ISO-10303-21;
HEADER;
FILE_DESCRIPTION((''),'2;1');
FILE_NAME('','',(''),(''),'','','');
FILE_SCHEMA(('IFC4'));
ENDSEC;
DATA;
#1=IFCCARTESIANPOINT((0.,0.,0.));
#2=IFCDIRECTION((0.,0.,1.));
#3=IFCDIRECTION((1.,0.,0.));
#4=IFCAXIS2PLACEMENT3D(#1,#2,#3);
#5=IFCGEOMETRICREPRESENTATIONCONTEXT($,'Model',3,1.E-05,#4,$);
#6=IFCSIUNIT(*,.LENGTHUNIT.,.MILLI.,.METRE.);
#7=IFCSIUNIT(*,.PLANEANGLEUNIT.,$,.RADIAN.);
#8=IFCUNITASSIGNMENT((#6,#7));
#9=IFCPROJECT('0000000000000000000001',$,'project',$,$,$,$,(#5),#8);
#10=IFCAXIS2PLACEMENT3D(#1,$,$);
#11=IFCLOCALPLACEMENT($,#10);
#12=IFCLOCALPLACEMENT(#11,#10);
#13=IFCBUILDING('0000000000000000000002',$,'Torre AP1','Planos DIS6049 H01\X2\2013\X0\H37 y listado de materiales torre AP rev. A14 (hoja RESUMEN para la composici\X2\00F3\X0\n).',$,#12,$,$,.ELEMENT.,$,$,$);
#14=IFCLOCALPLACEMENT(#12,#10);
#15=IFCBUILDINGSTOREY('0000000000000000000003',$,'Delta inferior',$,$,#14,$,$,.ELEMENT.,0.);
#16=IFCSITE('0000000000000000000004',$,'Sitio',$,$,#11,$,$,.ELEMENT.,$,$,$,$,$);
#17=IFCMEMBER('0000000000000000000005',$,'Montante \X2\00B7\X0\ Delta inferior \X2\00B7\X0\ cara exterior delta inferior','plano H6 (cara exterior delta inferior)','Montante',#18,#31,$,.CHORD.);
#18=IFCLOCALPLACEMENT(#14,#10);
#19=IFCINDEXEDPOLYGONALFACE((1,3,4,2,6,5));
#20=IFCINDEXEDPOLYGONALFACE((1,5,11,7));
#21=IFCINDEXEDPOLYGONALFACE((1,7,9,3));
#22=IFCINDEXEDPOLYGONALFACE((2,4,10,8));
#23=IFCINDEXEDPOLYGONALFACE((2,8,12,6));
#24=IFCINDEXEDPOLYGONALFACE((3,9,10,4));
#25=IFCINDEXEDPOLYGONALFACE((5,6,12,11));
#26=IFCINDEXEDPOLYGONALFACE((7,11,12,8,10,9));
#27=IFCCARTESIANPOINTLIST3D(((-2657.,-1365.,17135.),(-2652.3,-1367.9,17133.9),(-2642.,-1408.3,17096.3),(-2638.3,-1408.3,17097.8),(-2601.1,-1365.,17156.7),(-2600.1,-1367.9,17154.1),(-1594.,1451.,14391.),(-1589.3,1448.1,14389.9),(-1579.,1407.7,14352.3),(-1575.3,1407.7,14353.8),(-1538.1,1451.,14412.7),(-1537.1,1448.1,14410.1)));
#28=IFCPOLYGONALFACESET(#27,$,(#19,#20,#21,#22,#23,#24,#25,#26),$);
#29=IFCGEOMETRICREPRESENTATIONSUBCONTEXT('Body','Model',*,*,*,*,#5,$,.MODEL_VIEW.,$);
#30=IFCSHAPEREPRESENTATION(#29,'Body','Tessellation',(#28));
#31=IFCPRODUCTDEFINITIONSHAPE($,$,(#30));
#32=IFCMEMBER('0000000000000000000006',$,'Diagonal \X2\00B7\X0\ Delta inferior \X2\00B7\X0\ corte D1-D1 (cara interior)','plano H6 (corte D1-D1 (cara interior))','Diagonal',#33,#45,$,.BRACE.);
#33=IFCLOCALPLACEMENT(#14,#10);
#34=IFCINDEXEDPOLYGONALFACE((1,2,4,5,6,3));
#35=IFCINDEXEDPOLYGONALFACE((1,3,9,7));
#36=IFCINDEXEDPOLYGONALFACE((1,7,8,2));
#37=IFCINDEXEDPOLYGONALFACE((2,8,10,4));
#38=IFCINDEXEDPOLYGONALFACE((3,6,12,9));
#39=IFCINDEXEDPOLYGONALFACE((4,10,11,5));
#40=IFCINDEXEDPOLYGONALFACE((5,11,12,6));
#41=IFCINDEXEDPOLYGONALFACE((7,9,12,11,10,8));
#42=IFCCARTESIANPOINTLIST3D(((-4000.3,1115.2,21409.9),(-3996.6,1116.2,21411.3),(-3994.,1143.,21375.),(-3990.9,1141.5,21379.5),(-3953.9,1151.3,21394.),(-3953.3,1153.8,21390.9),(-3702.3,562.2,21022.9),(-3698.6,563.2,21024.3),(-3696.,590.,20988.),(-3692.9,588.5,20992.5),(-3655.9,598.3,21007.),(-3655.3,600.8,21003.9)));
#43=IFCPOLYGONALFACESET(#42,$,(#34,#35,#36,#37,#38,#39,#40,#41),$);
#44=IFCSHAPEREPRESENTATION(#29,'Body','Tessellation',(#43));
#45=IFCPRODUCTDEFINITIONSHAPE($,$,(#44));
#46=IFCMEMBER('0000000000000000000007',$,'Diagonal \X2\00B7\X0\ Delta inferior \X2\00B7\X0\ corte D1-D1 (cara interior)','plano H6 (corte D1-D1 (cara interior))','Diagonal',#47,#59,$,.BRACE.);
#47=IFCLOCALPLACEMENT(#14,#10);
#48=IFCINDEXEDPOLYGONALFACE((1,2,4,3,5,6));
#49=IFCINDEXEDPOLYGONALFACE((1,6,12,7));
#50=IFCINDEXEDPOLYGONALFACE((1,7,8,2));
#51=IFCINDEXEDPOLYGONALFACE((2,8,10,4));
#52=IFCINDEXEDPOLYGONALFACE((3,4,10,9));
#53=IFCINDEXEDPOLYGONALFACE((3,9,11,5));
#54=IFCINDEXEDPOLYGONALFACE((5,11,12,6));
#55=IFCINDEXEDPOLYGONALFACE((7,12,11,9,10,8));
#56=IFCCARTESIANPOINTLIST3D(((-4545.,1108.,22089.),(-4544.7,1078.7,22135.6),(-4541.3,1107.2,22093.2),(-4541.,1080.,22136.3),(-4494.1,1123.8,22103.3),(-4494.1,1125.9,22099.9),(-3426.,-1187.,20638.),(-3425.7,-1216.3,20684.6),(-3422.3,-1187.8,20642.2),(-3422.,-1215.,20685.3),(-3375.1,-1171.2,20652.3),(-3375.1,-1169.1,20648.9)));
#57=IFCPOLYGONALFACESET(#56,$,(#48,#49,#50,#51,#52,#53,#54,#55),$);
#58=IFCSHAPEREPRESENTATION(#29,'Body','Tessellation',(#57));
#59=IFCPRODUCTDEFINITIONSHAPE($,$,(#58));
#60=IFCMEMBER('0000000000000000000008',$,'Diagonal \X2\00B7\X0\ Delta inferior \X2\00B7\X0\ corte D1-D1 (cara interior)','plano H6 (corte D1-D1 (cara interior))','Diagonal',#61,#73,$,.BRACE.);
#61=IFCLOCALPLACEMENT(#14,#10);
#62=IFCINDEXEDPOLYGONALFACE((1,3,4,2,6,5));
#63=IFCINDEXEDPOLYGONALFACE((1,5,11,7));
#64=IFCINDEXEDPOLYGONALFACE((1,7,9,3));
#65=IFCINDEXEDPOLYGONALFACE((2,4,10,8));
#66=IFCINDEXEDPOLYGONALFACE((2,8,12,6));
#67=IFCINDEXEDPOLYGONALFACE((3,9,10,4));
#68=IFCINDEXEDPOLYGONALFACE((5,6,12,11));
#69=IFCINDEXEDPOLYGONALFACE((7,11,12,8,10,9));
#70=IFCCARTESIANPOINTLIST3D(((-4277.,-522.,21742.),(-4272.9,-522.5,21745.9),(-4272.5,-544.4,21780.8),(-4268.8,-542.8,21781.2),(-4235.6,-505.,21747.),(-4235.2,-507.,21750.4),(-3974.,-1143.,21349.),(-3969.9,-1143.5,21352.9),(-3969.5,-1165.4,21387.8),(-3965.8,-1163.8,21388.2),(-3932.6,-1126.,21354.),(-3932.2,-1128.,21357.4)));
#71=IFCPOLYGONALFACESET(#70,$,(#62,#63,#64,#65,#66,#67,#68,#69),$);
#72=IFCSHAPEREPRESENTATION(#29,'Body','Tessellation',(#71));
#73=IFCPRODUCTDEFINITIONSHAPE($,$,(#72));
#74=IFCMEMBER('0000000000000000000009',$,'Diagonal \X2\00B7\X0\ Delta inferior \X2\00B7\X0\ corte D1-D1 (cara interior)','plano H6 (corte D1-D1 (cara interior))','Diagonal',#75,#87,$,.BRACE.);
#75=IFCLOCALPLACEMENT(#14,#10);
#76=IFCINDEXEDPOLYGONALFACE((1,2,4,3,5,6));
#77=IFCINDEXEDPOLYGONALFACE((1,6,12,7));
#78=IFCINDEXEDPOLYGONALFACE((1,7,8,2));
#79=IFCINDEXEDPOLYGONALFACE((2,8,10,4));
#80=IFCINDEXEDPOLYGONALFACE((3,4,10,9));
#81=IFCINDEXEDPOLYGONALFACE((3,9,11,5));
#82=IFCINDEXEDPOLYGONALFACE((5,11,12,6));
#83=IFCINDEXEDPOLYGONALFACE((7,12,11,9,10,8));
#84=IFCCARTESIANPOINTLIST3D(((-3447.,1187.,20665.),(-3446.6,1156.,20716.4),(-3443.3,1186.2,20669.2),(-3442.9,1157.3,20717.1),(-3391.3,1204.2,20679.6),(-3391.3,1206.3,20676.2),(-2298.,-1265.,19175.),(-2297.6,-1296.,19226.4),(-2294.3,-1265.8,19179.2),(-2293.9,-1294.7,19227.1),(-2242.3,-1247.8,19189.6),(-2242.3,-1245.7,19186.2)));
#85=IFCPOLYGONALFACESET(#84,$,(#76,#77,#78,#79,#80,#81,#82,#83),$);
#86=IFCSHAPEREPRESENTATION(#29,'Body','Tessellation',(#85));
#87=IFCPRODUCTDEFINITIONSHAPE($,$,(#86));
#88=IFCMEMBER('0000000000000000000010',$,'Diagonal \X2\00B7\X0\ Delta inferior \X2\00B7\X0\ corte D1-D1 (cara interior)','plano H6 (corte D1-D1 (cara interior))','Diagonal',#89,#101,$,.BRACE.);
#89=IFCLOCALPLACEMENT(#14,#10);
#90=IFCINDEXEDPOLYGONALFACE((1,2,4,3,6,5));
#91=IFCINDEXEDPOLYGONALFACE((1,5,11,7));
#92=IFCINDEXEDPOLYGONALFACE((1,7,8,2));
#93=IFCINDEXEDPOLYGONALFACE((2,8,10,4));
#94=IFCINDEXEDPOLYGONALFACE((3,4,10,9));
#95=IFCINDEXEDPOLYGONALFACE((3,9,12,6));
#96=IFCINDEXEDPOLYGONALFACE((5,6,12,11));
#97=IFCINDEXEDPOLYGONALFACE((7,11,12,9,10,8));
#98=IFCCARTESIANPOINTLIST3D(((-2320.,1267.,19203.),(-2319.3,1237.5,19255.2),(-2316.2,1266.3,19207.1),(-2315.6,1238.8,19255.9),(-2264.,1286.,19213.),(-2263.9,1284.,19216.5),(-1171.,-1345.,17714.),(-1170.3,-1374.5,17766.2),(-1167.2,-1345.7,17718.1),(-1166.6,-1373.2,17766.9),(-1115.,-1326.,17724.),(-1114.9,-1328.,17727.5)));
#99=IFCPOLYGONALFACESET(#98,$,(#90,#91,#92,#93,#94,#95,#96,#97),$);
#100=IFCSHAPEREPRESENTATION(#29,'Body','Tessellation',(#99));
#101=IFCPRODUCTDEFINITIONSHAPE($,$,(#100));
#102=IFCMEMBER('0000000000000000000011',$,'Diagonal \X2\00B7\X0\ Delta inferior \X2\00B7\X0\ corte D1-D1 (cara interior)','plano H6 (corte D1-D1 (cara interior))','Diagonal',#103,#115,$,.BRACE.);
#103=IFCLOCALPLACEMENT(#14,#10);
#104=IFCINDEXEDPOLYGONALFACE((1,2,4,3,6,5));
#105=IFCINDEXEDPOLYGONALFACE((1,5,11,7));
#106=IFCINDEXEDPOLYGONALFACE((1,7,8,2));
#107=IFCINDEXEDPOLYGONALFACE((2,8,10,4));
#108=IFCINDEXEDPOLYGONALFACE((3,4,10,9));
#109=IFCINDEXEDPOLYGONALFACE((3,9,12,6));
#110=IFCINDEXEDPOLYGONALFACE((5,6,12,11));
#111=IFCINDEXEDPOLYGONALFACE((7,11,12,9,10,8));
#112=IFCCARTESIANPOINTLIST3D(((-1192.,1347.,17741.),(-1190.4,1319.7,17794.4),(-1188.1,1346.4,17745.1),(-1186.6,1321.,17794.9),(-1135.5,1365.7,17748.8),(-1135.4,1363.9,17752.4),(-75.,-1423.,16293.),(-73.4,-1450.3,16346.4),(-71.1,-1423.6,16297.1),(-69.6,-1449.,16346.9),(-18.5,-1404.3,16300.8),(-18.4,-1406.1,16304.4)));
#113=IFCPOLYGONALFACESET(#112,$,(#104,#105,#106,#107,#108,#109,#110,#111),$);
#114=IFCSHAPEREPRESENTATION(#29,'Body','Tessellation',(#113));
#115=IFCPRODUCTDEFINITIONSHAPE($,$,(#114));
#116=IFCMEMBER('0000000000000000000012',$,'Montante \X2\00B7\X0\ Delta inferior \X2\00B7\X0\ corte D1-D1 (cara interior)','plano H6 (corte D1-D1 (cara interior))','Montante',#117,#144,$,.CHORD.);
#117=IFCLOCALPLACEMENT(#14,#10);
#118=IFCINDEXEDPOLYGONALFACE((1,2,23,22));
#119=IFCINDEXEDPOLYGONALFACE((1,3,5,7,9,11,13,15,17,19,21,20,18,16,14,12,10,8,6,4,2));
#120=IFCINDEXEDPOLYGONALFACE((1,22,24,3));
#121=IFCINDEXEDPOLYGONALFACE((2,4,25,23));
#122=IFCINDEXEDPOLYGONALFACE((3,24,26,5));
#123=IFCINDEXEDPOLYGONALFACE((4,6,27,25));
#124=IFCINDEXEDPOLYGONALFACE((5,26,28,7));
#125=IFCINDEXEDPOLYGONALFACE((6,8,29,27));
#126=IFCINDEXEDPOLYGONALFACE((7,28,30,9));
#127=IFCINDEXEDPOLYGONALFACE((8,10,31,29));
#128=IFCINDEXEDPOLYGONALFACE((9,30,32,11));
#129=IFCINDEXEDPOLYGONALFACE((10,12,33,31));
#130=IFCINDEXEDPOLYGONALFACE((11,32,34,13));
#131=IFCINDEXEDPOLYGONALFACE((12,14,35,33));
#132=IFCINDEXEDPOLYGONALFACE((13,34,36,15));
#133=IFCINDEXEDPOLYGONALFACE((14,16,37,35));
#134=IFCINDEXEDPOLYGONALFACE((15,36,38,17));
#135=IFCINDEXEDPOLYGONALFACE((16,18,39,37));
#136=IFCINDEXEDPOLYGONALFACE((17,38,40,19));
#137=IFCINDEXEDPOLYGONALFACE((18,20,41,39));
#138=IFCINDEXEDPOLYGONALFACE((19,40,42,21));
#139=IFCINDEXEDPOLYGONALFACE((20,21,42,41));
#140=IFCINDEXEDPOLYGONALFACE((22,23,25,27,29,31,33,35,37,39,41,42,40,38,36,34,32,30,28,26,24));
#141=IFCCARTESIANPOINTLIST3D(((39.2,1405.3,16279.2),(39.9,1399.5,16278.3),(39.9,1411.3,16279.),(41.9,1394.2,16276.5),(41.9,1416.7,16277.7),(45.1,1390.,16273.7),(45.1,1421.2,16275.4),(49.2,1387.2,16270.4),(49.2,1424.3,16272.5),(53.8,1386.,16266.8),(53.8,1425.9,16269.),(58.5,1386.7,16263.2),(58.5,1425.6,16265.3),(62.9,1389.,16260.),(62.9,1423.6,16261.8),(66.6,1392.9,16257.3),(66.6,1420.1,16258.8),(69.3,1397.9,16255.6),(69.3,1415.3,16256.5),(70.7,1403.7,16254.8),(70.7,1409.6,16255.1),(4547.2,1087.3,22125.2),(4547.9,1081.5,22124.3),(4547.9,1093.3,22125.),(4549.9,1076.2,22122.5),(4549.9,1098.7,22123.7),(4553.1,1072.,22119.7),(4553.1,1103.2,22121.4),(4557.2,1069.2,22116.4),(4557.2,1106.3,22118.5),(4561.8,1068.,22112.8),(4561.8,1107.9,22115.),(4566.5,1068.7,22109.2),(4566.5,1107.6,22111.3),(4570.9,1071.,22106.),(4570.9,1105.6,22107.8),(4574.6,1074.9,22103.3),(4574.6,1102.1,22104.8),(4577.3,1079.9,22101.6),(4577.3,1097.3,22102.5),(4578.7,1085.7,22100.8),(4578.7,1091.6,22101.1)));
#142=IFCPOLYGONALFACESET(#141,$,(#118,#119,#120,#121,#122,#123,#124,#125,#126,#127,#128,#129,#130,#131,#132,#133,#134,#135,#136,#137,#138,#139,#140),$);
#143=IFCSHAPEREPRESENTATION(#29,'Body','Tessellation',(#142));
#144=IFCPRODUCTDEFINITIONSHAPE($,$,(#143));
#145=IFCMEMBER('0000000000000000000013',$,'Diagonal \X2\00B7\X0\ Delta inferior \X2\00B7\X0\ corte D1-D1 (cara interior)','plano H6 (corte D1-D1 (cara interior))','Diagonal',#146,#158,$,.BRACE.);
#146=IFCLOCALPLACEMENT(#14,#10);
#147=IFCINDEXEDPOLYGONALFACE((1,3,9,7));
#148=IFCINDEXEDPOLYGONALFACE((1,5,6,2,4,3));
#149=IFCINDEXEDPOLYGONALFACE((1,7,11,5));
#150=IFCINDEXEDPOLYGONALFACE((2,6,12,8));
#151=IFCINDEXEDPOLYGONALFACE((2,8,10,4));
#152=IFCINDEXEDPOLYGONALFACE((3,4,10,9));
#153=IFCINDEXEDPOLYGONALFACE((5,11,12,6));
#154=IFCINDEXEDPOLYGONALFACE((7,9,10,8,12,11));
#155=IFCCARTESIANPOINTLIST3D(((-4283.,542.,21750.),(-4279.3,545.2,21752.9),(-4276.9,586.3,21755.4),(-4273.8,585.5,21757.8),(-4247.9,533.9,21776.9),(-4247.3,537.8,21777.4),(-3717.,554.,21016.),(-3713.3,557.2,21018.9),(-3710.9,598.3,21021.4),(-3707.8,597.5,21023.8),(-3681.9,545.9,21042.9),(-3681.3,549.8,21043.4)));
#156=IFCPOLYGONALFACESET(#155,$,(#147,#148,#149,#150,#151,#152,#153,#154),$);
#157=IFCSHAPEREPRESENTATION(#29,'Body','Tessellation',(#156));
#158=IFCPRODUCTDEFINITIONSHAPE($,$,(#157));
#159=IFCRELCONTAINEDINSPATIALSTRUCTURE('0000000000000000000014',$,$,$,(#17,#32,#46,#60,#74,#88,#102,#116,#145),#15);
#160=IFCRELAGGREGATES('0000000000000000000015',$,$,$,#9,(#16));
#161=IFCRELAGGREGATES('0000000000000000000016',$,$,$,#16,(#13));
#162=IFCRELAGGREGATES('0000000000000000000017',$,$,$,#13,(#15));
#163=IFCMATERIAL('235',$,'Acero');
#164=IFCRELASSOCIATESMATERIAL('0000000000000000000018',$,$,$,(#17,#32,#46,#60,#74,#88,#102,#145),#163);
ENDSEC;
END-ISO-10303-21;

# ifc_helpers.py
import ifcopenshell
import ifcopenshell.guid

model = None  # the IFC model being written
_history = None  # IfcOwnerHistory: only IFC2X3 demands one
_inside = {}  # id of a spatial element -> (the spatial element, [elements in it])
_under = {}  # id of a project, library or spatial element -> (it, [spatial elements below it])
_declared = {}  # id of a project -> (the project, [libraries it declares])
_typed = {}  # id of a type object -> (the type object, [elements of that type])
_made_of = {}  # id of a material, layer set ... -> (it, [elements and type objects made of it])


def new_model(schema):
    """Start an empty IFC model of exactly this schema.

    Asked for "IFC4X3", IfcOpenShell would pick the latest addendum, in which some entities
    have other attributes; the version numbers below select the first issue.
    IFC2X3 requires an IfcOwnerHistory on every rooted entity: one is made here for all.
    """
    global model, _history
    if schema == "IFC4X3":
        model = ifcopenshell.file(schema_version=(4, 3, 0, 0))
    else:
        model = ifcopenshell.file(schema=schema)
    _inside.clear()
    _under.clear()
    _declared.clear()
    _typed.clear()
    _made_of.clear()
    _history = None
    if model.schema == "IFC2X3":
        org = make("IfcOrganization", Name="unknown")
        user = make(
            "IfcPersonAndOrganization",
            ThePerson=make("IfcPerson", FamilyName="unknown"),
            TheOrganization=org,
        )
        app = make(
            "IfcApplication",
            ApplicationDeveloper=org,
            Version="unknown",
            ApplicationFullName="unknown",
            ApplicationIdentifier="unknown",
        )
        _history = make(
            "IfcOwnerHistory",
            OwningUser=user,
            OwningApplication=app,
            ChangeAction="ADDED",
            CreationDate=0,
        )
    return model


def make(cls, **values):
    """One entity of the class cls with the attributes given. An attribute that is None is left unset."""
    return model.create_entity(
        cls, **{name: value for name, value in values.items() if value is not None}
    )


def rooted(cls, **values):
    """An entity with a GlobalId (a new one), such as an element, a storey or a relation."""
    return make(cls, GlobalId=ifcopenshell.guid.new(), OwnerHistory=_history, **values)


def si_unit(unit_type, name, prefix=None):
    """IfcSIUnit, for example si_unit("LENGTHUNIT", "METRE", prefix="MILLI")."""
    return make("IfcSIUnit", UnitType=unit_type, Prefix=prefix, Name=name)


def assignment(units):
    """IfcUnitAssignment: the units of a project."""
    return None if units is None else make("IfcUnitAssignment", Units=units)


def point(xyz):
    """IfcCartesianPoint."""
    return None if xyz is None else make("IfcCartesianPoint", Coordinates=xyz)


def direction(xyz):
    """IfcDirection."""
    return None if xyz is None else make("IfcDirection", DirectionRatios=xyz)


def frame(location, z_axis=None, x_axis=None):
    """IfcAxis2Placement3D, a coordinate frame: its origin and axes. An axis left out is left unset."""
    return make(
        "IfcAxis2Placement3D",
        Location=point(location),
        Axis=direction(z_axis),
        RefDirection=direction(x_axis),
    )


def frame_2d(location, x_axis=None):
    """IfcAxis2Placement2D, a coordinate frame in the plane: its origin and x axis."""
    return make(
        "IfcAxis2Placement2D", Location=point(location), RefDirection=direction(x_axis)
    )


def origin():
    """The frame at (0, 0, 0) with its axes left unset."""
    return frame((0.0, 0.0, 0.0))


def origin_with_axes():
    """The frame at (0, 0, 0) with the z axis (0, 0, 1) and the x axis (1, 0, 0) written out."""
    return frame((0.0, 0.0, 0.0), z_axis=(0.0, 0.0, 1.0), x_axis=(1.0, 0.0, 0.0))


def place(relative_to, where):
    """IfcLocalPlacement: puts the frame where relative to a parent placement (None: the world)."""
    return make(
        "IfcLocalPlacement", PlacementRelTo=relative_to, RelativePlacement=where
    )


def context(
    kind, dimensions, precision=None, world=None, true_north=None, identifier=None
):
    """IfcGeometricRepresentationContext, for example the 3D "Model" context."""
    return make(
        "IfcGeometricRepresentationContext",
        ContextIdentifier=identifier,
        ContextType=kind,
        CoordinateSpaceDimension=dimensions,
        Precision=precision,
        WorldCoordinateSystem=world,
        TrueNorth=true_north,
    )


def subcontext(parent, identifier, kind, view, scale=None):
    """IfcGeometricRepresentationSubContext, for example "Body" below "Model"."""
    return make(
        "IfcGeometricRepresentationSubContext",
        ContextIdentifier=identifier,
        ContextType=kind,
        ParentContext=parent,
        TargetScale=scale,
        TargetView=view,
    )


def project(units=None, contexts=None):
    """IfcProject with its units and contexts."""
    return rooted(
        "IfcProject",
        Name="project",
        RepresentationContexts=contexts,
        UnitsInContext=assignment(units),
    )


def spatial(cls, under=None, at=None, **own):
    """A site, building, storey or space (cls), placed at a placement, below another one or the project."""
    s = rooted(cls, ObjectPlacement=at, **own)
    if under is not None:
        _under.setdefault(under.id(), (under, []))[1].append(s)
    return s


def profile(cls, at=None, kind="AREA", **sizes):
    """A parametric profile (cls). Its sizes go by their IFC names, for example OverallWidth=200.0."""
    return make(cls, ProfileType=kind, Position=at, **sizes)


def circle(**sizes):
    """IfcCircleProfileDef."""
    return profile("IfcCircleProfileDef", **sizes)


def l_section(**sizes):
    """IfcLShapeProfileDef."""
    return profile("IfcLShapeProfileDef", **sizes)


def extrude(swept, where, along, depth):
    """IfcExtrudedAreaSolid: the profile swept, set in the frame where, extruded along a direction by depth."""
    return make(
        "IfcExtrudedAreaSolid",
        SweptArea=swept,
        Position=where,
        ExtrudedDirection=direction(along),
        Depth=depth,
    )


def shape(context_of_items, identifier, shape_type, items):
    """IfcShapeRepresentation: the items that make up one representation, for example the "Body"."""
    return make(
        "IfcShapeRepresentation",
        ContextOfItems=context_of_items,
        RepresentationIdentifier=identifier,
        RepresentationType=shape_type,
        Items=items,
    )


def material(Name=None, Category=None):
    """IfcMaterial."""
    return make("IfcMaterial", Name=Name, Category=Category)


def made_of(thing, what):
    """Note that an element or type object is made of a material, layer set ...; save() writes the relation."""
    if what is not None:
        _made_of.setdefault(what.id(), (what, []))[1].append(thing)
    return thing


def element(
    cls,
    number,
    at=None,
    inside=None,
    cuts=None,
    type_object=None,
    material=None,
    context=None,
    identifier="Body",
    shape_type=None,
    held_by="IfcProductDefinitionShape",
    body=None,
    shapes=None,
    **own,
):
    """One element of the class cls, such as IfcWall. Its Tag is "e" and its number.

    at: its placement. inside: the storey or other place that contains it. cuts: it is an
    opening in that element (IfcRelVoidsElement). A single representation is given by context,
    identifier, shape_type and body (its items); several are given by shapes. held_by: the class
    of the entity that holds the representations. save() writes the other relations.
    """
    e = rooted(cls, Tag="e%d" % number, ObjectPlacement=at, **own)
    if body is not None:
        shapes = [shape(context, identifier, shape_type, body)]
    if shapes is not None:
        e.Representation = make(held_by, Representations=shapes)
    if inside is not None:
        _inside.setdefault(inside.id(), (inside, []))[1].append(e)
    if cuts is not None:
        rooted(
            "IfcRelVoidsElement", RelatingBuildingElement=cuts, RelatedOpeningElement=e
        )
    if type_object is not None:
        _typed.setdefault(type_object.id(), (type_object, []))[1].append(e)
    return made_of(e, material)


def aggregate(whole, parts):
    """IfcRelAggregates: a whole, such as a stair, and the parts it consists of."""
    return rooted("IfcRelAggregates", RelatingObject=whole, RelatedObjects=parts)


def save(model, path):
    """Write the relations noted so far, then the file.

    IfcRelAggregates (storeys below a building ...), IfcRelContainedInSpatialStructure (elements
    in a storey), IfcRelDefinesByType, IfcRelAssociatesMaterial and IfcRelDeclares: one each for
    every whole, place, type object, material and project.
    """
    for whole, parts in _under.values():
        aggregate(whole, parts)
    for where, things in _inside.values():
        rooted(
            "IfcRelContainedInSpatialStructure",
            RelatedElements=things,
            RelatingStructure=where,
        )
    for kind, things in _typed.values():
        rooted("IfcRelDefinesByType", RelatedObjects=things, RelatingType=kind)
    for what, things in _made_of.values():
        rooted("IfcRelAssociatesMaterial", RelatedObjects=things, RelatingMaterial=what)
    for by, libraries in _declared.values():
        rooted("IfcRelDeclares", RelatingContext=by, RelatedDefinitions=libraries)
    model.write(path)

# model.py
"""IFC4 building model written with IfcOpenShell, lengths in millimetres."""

from ifc_helpers import new_model, si_unit, frame, frame_2d, origin, origin_with_axes, place, context, subcontext, project, spatial, circle, l_section, extrude, material, element, save


model = new_model("IFC4")

# Units and contexts
model_context = context("Model", 3, precision=1e-05, world=origin_with_axes())
body_context = subcontext(model_context, "Body", "Model", "MODEL_VIEW")
ifc_project = project(units=[si_unit("LENGTHUNIT", "METRE", prefix="MILLI"), si_unit("PLANEANGLEUNIT", "RADIAN")], contexts=[model_context])

# Site, building, storey
site_placement = place(None, origin())
site = spatial("IfcSite", under=ifc_project, at=site_placement, Name="Sitio", CompositionType="ELEMENT")
building_placement = place(site_placement, origin())
building = spatial("IfcBuilding", under=site, at=building_placement, Name="Torre AP1", Description="Planos DIS6049 H01–H37 y listado de materiales torre AP rev. A14 (hoja RESUMEN para la composición).", CompositionType="ELEMENT")
storey_placement = place(building_placement, origin())
storey = spatial("IfcBuildingStorey", under=building, at=storey_placement, Name="Delta inferior", CompositionType="ELEMENT", Elevation=0.0)

# Members
ifc_material_1 = material(Name="235", Category="Acero")
member_1_placement = place(storey_placement, frame((-1594.0, 1451.0, 14391.0), z_axis=(-0.260987, -0.691382, 0.673704), x_axis=(0.249749, -0.72249, -0.644697)))
element("IfcMember", 1, at=member_1_placement, inside=storey, material=ifc_material_1, Name="Montante · Delta inferior · cara exterior delta inferior", Description="plano H6 (cara exterior delta inferior)", ObjectType="Montante", PredefinedType="CHORD", context=body_context, shape_type="SweptSolid", body=[
    extrude(l_section(Depth=60.0, Width=60.0, Thickness=4.0, at=frame_2d((30.0, 30.0))), None, (0.0, 0.0, 1.0), 4073.0),
])
member_2_placement = place(storey_placement, frame((-3994.0, 1143.0, 21375.0), z_axis=(0.403891, -0.749503, -0.524516), x_axis=(0.904178, 0.239916, 0.353414)))
element("IfcMember", 2, at=member_2_placement, inside=storey, material=ifc_material_1, Name="Diagonal · Delta inferior · corte D1-D1 (cara interior)", Description="plano H6 (corte D1-D1 (cara interior))", ObjectType="Diagonal", PredefinedType="BRACE", context=body_context, shape_type="SweptSolid", body=[
    extrude(l_section(Depth=45.0, Width=45.0, Thickness=4.0, at=frame_2d((22.5, 22.5))), None, (0.0, 0.0, 1.0), 737.8),
])
member_3_placement = place(storey_placement, frame((-4545.0, 1108.0, 22089.0), z_axis=(0.381032, -0.781472, -0.494081), x_axis=(0.924547, 0.325107, 0.198793)))
element("IfcMember", 3, at=member_3_placement, inside=storey, material=ifc_material_1, Name="Diagonal · Delta inferior · corte D1-D1 (cara interior)", Description="plano H6 (corte D1-D1 (cara interior))", ObjectType="Diagonal", PredefinedType="BRACE", context=body_context, shape_type="SweptSolid", body=[
    extrude(l_section(Depth=55.0, Width=55.0, Thickness=4.0, at=frame_2d((27.5, 27.5))), None, (0.0, 0.0, 1.0), 2936.8),
])
member_4_placement = place(storey_placement, frame((-4277.0, -522.0, 21742.0), z_axis=(0.38117, -0.78121, -0.494389), x_axis=(0.919056, 0.378167, 0.111023)))
element("IfcMember", 4, at=member_4_placement, inside=storey, material=ifc_material_1, Name="Diagonal · Delta inferior · corte D1-D1 (cara interior)", Description="plano H6 (corte D1-D1 (cara interior))", ObjectType="Diagonal", PredefinedType="BRACE", context=body_context, shape_type="SweptSolid", body=[
    extrude(l_section(Depth=45.0, Width=45.0, Thickness=4.0, at=frame_2d((22.5, 22.5))), None, (0.0, 0.0, 1.0), 794.9),
])
member_5_placement = place(storey_placement, frame((-3447.0, 1187.0, 20665.0), z_axis=(0.371757, -0.79334, -0.482087), x_axis=(0.928304, 0.321616, 0.18659)))
element("IfcMember", 5, at=member_5_placement, inside=storey, material=ifc_material_1, Name="Diagonal · Delta inferior · corte D1-D1 (cara interior)", Description="plano H6 (corte D1-D1 (cara interior))", ObjectType="Diagonal", PredefinedType="BRACE", context=body_context, shape_type="SweptSolid", body=[
    extrude(l_section(Depth=60.0, Width=60.0, Thickness=4.0, at=frame_2d((30.0, 30.0))), None, (0.0, 0.0, 1.0), 3090.7),
])
member_6_placement = place(storey_placement, frame((-2320.0, 1267.0, 19203.0), z_axis=(0.356979, -0.811514, -0.462613), x_axis=(0.934048, 0.315929, 0.166565)))
element("IfcMember", 6, at=member_6_placement, inside=storey, material=ifc_material_1, Name="Diagonal · Delta inferior · corte D1-D1 (cara interior)", Description="plano H6 (corte D1-D1 (cara interior))", ObjectType="Diagonal", PredefinedType="BRACE", context=body_context, shape_type="SweptSolid", body=[
    extrude(l_section(Depth=60.0, Width=60.0, Thickness=4.0, at=frame_2d((30.0, 30.0))), None, (0.0, 0.0, 1.0), 3218.7),
])
member_7_placement = place(storey_placement, frame((-1192.0, 1347.0, 17741.0), z_axis=(0.336524, -0.834531, -0.436246), x_axis=(0.94128, 0.311519, 0.130181)))
element("IfcMember", 7, at=member_7_placement, inside=storey, material=ifc_material_1, Name="Diagonal · Delta inferior · corte D1-D1 (cara interior)", Description="plano H6 (corte D1-D1 (cara interior))", ObjectType="Diagonal", PredefinedType="BRACE", context=body_context, shape_type="SweptSolid", body=[
    extrude(l_section(Depth=60.0, Width=60.0, Thickness=4.0, at=frame_2d((30.0, 30.0))), None, (0.0, 0.0, 1.0), 3319.2),
])
for number, where, z_axis, x_axis, name in (
    (8, (55.0, 1406.0, 16267.0), (0.610087, -0.043036, 0.791165), (-0.792334, -0.033137, 0.609187), "Montante · Delta inferior · corte D1-D1 (cara interior)"),
):
    element("IfcMember", number, at=place(storey_placement, frame(where, z_axis=z_axis, x_axis=x_axis)), inside=storey, Name=name, Description="plano H6 (corte D1-D1 (cara interior))", ObjectType="Montante", PredefinedType="CHORD", context=body_context, shape_type="SweptSolid", body=[
        extrude(circle(Radius=20.0), None, (0.0, 0.0, 1.0), 7389.1),
    ])
member_8_placement = place(storey_placement, frame((-3717.0, 554.0, 21016.0), z_axis=(-0.610598, -0.012946, 0.791835), x_axis=(0.780393, -0.179966, 0.598832)))
element("IfcMember", 9, at=member_8_placement, inside=storey, material=ifc_material_1, Name="Diagonal · Delta inferior · corte D1-D1 (cara interior)", Description="plano H6 (corte D1-D1 (cara interior))", ObjectType="Diagonal", PredefinedType="BRACE", context=body_context, shape_type="SweptSolid", body=[
    extrude(l_section(Depth=45.0, Width=45.0, Thickness=4.0, at=frame_2d((22.5, 22.5))), None, (0.0, 0.0, 1.0), 927.0),
])

save(model, "model.ifc")
